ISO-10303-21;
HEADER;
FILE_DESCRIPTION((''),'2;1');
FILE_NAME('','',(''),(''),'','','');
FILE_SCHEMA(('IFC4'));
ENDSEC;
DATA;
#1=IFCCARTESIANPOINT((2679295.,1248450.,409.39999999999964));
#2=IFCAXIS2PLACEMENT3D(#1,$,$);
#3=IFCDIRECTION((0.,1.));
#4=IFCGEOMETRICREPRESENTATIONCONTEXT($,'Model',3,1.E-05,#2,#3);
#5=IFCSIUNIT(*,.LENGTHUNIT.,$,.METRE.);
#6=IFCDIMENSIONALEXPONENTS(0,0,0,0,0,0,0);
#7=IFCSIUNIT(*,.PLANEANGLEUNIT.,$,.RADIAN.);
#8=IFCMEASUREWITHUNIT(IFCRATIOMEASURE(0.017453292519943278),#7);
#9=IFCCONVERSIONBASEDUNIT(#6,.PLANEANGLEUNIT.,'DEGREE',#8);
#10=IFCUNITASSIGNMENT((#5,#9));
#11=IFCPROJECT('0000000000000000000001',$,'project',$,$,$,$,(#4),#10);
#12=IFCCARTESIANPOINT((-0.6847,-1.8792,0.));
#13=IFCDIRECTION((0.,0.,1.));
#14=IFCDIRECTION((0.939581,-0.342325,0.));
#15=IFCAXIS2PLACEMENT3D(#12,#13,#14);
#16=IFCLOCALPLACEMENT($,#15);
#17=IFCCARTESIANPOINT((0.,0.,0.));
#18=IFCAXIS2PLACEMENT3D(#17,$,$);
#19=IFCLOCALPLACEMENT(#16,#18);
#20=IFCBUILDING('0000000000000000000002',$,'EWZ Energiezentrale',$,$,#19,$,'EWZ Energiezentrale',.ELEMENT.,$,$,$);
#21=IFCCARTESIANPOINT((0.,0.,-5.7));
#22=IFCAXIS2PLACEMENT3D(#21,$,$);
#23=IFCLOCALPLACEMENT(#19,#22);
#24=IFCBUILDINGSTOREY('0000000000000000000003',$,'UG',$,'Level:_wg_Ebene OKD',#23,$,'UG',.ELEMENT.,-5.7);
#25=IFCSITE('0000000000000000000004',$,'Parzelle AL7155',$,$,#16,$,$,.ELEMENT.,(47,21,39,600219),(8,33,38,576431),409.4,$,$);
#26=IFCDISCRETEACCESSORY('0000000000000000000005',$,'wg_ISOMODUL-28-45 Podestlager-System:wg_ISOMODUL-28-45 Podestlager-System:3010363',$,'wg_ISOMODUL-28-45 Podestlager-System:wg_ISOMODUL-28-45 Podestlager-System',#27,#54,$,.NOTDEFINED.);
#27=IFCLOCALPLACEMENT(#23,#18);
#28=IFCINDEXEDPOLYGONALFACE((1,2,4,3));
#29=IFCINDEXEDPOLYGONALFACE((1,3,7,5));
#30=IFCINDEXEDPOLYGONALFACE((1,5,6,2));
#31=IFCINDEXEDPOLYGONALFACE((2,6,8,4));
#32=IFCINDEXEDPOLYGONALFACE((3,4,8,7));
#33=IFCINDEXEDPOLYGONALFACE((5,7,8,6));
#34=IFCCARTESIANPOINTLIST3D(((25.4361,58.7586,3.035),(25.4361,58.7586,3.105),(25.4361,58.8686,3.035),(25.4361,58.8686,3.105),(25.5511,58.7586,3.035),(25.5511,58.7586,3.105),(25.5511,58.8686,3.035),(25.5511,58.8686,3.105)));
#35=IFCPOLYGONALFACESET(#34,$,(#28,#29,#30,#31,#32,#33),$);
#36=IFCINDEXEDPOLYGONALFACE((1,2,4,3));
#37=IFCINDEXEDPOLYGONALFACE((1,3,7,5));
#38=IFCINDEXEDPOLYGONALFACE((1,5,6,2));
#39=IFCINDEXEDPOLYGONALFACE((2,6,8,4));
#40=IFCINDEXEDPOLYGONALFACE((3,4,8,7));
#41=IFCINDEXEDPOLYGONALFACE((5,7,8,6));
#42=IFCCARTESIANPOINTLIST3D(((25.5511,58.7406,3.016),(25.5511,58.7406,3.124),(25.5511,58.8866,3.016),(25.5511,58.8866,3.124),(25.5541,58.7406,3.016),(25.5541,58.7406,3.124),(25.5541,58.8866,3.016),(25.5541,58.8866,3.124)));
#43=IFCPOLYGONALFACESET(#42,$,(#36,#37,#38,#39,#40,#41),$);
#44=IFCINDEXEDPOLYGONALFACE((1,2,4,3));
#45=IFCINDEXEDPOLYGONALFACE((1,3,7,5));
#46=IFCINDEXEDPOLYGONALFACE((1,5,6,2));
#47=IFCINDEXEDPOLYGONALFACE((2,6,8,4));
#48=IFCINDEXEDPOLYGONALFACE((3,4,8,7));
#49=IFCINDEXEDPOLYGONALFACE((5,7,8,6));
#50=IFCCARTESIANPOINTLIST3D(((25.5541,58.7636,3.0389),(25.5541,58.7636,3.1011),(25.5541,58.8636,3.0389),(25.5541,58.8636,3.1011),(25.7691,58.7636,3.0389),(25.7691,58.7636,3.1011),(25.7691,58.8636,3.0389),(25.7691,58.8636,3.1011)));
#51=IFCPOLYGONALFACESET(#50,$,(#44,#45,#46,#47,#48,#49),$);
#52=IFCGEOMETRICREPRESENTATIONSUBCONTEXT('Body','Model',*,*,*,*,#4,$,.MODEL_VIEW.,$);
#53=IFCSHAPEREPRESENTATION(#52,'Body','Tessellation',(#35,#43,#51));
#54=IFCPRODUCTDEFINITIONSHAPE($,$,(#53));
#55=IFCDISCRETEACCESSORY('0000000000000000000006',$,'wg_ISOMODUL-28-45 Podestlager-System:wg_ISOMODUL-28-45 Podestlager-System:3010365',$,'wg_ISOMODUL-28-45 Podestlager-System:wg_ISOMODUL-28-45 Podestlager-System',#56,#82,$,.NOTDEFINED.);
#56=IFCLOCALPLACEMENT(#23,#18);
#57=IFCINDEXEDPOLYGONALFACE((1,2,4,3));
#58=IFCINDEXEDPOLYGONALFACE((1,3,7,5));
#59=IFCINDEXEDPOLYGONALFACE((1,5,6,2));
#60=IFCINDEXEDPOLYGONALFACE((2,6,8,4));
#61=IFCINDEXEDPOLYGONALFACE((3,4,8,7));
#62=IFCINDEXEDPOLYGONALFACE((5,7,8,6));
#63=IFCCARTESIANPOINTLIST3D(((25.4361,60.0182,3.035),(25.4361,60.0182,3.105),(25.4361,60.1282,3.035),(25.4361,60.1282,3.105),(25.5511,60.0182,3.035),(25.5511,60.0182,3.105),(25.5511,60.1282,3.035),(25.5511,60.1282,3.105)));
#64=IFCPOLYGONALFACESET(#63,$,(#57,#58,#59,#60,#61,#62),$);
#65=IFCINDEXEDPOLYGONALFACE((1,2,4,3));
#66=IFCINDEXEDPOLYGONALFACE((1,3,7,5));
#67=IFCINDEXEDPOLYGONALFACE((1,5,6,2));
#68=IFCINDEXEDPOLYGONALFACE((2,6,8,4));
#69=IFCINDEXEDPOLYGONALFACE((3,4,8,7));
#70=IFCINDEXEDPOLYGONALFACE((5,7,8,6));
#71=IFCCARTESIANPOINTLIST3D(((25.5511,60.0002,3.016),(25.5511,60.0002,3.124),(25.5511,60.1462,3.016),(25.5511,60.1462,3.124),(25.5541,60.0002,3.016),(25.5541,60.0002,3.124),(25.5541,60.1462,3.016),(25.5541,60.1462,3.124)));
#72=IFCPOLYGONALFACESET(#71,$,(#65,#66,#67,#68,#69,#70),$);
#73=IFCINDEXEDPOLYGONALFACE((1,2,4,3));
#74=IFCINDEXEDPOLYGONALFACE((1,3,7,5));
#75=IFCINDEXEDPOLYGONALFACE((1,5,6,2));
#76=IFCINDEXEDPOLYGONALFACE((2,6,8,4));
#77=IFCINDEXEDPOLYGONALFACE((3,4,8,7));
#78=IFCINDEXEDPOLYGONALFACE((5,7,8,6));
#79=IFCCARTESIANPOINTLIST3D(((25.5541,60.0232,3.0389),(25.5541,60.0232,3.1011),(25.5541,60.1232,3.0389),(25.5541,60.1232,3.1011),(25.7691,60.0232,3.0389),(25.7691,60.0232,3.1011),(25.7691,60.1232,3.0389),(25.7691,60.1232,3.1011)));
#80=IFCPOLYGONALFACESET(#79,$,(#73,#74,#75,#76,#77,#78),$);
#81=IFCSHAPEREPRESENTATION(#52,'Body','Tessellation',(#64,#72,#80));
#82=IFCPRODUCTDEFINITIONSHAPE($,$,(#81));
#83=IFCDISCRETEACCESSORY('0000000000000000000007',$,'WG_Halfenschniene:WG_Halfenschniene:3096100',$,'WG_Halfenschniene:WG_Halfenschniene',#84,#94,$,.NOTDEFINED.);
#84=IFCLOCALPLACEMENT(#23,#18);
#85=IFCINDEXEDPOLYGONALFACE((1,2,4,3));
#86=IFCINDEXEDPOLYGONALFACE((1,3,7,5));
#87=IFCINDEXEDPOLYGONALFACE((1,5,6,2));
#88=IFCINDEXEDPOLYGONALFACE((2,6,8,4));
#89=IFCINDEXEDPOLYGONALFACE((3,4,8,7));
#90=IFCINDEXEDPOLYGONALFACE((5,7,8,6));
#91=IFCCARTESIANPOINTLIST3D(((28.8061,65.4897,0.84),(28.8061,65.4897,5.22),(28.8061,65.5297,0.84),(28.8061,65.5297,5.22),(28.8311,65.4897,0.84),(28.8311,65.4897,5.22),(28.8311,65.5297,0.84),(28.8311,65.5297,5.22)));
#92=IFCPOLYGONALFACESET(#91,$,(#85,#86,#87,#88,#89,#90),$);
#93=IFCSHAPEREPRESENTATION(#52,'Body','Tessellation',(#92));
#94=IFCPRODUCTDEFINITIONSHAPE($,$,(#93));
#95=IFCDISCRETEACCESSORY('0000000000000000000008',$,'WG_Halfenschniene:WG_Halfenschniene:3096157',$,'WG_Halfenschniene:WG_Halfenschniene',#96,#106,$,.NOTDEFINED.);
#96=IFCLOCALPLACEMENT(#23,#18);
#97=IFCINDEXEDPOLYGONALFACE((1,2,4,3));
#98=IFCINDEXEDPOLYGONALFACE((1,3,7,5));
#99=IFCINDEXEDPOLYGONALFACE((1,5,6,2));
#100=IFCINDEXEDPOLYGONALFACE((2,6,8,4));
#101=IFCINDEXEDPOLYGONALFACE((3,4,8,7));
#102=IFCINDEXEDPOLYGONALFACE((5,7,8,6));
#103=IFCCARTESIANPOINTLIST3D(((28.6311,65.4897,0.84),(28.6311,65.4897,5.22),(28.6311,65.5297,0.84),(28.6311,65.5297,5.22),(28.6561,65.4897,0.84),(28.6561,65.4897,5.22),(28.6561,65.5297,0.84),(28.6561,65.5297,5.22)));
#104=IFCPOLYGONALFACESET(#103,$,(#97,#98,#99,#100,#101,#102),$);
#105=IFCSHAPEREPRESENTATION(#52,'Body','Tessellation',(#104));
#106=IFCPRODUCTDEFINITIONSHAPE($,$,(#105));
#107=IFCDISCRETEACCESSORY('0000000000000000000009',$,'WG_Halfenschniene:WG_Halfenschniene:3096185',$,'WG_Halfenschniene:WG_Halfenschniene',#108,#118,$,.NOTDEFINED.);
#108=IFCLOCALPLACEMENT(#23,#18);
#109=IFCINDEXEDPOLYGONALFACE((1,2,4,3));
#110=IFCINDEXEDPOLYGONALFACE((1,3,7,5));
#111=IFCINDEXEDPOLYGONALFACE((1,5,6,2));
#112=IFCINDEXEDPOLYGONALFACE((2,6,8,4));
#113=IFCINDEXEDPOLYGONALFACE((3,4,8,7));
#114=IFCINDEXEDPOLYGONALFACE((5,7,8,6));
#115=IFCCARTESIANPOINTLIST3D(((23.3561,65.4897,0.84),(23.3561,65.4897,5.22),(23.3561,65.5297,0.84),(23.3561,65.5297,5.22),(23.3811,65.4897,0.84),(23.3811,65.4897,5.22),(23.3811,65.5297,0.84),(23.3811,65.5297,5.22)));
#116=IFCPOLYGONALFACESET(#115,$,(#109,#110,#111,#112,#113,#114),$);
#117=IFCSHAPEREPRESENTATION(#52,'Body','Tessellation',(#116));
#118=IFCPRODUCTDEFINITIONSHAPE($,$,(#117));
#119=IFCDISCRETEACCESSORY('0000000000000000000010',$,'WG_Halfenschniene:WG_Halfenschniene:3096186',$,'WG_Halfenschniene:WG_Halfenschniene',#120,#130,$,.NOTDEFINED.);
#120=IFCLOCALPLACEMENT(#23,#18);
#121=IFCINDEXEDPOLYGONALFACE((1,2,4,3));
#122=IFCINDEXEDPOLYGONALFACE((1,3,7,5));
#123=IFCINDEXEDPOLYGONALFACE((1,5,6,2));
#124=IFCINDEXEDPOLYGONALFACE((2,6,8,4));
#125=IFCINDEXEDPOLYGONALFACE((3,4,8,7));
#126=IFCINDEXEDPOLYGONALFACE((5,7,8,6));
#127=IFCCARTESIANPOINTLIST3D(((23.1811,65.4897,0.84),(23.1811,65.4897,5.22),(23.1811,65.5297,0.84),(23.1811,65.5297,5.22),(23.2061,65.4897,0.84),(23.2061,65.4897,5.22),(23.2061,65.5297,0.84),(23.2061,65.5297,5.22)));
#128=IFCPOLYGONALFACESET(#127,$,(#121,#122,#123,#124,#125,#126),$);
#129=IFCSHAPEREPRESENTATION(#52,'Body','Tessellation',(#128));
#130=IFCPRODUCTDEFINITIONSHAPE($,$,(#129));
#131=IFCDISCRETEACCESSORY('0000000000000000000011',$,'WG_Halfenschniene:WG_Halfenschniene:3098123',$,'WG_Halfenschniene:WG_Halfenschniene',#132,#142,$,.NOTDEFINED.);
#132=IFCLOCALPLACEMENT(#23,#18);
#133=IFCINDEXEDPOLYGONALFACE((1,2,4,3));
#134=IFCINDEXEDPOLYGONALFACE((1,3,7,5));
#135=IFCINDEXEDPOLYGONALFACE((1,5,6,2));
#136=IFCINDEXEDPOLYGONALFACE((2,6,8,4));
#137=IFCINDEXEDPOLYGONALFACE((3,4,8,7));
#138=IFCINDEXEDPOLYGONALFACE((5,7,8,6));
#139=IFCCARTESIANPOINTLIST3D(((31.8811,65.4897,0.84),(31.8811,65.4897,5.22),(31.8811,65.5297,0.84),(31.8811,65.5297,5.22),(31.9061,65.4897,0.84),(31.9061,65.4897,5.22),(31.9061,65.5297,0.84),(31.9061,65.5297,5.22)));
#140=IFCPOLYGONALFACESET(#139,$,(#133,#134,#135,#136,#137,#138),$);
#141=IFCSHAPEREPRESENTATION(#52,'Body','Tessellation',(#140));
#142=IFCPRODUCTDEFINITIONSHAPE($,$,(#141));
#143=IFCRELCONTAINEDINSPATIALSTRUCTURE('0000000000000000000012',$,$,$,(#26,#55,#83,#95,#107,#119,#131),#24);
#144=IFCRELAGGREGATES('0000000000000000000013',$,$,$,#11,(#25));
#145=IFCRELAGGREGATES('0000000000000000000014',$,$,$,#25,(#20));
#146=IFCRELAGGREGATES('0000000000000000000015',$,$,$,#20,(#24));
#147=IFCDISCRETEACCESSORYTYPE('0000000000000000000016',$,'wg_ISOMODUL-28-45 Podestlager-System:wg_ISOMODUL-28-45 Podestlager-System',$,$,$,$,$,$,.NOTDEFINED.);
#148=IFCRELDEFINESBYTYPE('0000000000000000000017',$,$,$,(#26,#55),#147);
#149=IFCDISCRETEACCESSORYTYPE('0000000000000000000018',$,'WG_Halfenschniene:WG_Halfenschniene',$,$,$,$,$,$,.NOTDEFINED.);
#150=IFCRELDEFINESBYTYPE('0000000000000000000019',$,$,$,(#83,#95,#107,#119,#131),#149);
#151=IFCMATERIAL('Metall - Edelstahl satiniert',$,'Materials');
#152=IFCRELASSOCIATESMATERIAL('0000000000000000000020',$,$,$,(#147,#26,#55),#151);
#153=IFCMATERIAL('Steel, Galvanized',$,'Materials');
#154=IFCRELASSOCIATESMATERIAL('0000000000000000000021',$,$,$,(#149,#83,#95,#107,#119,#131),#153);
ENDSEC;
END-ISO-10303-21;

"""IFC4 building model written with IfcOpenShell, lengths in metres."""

from ifc_helpers import new_model, entity, si_unit, converted_unit, direction, frame, origin, place, context, subcontext, project, spatial, indexed_curve, outline, extrude, source, transform, mapped, material, type_object, element, save


model = new_model("IFC4")

# Units and contexts
model_context = context("Model", 3, precision=1e-05, world=frame((2679295.0, 1248450.0, 409.39999999999964)), true_north=direction((0.0, 1.0)))
body_context = subcontext(model_context, "Body", "Model", "MODEL_VIEW")
ifc_project = project(units=[si_unit("LENGTHUNIT", "METRE"), converted_unit("PLANEANGLEUNIT", "DEGREE", entity("IfcRatioMeasure", 0.017453292519943278), si_unit("PLANEANGLEUNIT", "RADIAN"), dimensions=[0, 0, 0, 0, 0, 0, 0])], contexts=[model_context])

# Site, building, storey
site_placement = place(None, frame((-0.6847, -1.8792, 0.0), z_axis=(0.0, 0.0, 1.0), x_axis=(0.939581, -0.342325, 0.0)))
site = spatial("IfcSite", under=ifc_project, at=site_placement, Name="Parzelle AL7155", CompositionType="ELEMENT", RefLatitude=(47, 21, 39, 600219), RefLongitude=(8, 33, 38, 576431), RefElevation=409.4)
building_placement = place(site_placement, origin())
building = spatial("IfcBuilding", under=site, at=building_placement, Name="EWZ Energiezentrale", LongName="EWZ Energiezentrale", CompositionType="ELEMENT")
storey_placement = place(building_placement, frame((0.0, 0.0, -5.7)))
storey = spatial("IfcBuildingStorey", under=building, at=storey_placement, Name="UG", ObjectType="Level:_wg_Ebene OKD", LongName="UG", CompositionType="ELEMENT", Elevation=-5.7)

# Discrete accessories
ifc_material_1 = material(Name="Metall - Edelstahl satiniert", Category="Materials")
discrete_accessory_type_1 = type_object("IfcDiscreteAccessoryType", Name="wg_ISOMODUL-28-45 Podestlager-System:wg_ISOMODUL-28-45 Podestlager-System", PredefinedType="NOTDEFINED", material=ifc_material_1)
shared_shape_1 = source(origin(), body_context, "Body", "SweptSolid", [
    extrude(outline(indexed_curve([(-0.0575, -0.055), (0.0575, -0.055), (0.0575, 0.055), (-0.0575, 0.055), (-0.0575, -0.055)], self_intersect=False)), frame((0.0, 0.0575, 0.0), z_axis=(0.0, 0.0, 1.0), x_axis=(0.0, 1.0, 0.0)), (0.0, 0.0, 1.0), 0.07),
    extrude(outline(indexed_curve([(-0.0015, -0.073), (0.0015, -0.073), (0.0015, 0.073), (-0.0015, 0.073), (-0.0015, -0.073)], self_intersect=False)), frame((0.0, -0.0015, -0.019), z_axis=(0.0, 0.0, 1.0), x_axis=(0.0, 1.0, 0.0)), (0.0, 0.0, 1.0), 0.108),
    extrude(outline(indexed_curve([(-0.1075, -0.05), (0.1075, -0.05), (0.1075, 0.05), (-0.1075, 0.05), (-0.1075, -0.05)], self_intersect=False)), frame((0.0, -0.1105, 0.0039), z_axis=(0.0, 0.0, 1.0), x_axis=(0.0, 1.0, 0.0)), (0.0, 0.0, 1.0), 0.0621),
])
for number, where, z_axis, x_axis, name in (
    (1, (25.5511, 58.8136, 3.035), (0.0, 0.0, 1.0), (0.0, 1.0, 0.0), "wg_ISOMODUL-28-45 Podestlager-System:wg_ISOMODUL-28-45 Podestlager-System:3010363"),
    (2, (25.5511, 60.0732, 3.035), (0.0, 0.0, 1.0), (0.0, 1.0, 0.0), "wg_ISOMODUL-28-45 Podestlager-System:wg_ISOMODUL-28-45 Podestlager-System:3010365"),
):
    element("IfcDiscreteAccessory", number, at=place(storey_placement, frame(where, z_axis=z_axis, x_axis=x_axis)), inside=storey, type_object=discrete_accessory_type_1, material=ifc_material_1, Name=name, ObjectType="wg_ISOMODUL-28-45 Podestlager-System:wg_ISOMODUL-28-45 Podestlager-System", PredefinedType="NOTDEFINED", context=body_context, shape_type="MappedRepresentation", body=[
        mapped(shared_shape_1, transform((0.0, 0.0, 0.0), scale=1.0)),
    ])
ifc_material_2 = material(Name="Steel, Galvanized", Category="Materials")
discrete_accessory_type_2 = type_object("IfcDiscreteAccessoryType", Name="WG_Halfenschniene:WG_Halfenschniene", PredefinedType="NOTDEFINED", material=ifc_material_2)
shared_shape_2 = source(origin(), body_context, "Body", "SweptSolid", [
    extrude(outline(indexed_curve([(-2.19, -0.02), (2.19, -0.02), (2.19, 0.02), (-2.19, 0.02), (-2.19, -0.02)], self_intersect=False)), frame((2.19, 0.0, -0.0125)), (0.0, 0.0, 1.0), 0.025),
])
for number, where, z_axis, x_axis, name in (
    (3, (28.8186, 65.5097, 5.22), (1.0, 0.0, 0.0), (0.0, 0.0, -1.0), "WG_Halfenschniene:WG_Halfenschniene:3096100"),
    (4, (28.6436, 65.5097, 5.22), (1.0, 0.0, 0.0), (0.0, 0.0, -1.0), "WG_Halfenschniene:WG_Halfenschniene:3096157"),
    (5, (23.3686, 65.5097, 5.22), (1.0, 0.0, 0.0), (0.0, 0.0, -1.0), "WG_Halfenschniene:WG_Halfenschniene:3096185"),
    (6, (23.1936, 65.5097, 5.22), (1.0, 0.0, 0.0), (0.0, 0.0, -1.0), "WG_Halfenschniene:WG_Halfenschniene:3096186"),
    (7, (31.8936, 65.5097, 5.22), (1.0, 0.0, 0.0), (0.0, 0.0, -1.0), "WG_Halfenschniene:WG_Halfenschniene:3098123"),
):
    element("IfcDiscreteAccessory", number, at=place(storey_placement, frame(where, z_axis=z_axis, x_axis=x_axis)), inside=storey, type_object=discrete_accessory_type_2, material=ifc_material_2, Name=name, ObjectType="WG_Halfenschniene:WG_Halfenschniene", PredefinedType="NOTDEFINED", context=body_context, shape_type="MappedRepresentation", body=[
        mapped(shared_shape_2, transform((0.0, 0.0, 0.0), scale=1.0)),
    ])

save(model, "model.ifc")
